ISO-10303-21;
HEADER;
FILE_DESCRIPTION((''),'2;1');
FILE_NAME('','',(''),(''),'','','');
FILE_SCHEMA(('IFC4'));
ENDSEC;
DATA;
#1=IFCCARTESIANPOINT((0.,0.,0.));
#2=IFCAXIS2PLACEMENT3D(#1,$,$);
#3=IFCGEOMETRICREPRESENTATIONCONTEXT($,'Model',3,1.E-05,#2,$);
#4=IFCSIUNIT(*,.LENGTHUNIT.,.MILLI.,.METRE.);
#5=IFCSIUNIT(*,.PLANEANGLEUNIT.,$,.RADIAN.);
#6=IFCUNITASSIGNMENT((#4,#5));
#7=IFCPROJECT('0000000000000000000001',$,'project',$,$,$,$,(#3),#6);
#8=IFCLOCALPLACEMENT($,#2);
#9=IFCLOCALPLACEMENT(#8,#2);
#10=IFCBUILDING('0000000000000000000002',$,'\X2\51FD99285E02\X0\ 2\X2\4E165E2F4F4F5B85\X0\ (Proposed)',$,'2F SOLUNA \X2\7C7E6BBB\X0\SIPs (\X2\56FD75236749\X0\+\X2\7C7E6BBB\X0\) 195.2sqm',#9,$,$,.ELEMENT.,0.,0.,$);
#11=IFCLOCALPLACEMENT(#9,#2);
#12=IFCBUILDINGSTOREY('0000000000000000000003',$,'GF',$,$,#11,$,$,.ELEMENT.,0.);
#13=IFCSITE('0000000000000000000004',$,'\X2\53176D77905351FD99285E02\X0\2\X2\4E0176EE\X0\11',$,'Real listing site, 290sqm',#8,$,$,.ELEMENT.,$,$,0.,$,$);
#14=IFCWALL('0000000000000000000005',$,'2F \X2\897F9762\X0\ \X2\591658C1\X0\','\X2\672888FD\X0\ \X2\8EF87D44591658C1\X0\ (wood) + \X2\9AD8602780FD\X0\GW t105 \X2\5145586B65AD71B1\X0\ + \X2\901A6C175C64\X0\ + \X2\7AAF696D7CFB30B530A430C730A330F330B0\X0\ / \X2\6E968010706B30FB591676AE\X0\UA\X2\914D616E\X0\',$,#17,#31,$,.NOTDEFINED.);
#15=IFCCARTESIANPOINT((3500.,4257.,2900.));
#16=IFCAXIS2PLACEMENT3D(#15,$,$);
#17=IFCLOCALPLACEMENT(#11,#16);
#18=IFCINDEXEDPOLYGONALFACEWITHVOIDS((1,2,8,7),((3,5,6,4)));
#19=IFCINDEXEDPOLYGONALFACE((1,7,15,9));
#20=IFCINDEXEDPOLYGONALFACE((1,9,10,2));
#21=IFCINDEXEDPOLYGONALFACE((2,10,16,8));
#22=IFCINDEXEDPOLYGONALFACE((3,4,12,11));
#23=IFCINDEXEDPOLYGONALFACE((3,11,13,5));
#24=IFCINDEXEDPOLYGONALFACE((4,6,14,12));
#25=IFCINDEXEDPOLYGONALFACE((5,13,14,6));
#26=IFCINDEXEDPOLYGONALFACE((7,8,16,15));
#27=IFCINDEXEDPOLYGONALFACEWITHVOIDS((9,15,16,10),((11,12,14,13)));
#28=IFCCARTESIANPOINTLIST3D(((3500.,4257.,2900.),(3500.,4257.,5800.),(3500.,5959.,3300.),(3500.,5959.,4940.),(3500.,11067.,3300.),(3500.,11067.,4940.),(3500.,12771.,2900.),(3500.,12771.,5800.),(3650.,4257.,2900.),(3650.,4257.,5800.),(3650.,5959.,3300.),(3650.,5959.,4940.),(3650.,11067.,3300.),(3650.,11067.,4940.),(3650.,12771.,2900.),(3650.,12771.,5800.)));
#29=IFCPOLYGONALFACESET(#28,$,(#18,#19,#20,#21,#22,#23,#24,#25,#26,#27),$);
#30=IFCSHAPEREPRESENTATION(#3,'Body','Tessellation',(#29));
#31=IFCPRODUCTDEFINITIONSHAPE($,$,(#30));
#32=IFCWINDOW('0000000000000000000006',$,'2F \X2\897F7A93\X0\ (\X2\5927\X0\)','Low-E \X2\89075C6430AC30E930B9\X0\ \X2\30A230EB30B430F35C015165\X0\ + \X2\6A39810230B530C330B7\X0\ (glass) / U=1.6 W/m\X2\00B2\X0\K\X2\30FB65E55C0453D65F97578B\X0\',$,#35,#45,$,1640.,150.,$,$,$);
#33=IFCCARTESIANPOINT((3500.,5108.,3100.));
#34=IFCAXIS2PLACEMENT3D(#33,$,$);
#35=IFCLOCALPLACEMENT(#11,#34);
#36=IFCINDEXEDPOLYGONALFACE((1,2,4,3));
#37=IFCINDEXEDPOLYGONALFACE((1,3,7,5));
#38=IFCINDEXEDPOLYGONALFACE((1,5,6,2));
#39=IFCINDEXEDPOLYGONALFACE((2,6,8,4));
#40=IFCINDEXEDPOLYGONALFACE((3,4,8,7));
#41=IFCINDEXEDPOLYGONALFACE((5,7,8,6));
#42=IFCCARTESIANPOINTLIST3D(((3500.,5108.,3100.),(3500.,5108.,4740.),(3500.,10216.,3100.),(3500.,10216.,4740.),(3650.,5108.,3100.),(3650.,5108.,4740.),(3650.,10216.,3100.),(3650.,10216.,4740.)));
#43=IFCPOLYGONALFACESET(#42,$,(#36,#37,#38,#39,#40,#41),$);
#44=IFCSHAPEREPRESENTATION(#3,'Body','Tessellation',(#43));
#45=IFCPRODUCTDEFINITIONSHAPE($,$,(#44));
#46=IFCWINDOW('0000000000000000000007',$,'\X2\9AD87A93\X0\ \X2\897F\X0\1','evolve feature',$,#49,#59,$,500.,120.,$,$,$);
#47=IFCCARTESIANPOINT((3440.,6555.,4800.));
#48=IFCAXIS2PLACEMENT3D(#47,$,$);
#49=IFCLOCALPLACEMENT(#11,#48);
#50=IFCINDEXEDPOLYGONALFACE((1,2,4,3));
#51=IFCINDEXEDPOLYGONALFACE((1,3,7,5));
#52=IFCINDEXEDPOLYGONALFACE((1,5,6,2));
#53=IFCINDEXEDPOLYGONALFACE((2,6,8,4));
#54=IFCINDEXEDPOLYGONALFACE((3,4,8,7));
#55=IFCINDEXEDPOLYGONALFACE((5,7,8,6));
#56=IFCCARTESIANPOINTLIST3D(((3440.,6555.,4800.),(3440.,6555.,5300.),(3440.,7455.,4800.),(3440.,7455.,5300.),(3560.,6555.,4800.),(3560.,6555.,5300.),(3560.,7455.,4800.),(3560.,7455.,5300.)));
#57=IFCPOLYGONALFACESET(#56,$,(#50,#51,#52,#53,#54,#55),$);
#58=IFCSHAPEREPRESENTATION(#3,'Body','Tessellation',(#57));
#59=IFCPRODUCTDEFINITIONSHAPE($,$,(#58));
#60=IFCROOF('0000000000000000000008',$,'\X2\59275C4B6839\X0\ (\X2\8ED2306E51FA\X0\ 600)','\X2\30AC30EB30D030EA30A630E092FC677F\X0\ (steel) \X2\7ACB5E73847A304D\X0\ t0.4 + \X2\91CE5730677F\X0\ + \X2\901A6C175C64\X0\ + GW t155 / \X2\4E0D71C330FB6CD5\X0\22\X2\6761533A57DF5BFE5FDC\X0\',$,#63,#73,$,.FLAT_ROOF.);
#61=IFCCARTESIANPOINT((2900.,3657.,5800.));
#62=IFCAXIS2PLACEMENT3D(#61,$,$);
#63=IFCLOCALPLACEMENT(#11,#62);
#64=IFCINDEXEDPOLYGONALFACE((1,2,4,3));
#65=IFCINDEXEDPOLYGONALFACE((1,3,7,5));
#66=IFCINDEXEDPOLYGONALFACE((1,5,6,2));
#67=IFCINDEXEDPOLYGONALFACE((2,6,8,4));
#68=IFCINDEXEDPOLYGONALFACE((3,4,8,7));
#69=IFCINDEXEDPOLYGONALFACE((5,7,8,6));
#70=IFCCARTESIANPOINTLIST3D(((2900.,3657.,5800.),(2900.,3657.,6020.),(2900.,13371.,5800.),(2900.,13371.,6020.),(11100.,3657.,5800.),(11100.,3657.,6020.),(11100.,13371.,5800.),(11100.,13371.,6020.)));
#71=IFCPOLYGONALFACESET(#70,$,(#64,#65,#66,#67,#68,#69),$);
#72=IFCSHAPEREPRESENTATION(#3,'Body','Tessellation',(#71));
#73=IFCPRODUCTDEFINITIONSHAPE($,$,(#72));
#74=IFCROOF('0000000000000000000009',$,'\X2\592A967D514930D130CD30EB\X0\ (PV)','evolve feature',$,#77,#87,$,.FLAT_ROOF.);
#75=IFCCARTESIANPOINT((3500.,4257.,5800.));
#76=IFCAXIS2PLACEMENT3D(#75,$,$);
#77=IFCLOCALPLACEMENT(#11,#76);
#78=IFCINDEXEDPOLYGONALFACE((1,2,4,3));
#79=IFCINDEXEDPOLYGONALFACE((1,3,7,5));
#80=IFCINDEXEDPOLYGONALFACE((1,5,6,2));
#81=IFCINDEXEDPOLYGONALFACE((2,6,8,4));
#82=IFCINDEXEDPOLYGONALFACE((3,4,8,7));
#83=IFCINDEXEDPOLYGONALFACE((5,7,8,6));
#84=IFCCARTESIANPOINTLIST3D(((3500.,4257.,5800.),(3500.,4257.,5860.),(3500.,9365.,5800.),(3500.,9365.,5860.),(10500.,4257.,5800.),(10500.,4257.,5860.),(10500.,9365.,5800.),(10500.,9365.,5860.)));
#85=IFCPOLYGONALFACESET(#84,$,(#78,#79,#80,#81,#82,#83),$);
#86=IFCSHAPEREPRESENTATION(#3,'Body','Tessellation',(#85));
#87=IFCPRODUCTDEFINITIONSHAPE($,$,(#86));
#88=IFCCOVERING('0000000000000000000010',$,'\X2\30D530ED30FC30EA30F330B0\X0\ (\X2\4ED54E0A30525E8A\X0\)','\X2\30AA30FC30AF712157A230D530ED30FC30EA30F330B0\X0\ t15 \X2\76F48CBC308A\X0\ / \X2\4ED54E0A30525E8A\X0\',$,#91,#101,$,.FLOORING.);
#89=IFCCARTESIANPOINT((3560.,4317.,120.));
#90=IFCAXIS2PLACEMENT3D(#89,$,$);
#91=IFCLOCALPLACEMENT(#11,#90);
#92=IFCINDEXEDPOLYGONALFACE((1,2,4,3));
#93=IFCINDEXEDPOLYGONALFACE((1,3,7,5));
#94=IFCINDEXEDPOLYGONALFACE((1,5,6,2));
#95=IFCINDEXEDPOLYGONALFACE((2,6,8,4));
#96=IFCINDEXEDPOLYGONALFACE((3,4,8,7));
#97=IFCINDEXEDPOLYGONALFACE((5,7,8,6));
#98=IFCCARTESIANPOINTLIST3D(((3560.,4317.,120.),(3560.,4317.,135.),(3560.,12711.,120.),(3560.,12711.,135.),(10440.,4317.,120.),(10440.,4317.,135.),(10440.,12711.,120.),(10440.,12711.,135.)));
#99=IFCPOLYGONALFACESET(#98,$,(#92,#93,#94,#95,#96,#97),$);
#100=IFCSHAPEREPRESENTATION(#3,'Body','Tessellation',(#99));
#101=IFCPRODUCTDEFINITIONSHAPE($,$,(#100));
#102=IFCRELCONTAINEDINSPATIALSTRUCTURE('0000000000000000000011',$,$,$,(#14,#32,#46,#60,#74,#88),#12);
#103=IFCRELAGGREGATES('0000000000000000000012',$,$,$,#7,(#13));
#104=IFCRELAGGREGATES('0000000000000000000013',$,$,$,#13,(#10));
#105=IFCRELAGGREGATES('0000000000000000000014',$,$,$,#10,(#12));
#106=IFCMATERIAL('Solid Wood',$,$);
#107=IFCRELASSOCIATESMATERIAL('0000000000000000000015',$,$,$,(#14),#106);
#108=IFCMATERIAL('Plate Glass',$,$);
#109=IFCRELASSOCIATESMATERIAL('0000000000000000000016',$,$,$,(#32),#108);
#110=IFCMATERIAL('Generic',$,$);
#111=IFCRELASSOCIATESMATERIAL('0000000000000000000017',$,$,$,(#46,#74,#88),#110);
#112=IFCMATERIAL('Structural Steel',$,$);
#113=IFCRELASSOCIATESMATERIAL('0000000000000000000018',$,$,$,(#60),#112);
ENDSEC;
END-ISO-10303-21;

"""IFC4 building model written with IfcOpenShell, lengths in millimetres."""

from ifc_helpers import new_model, si_unit, frame, frame_2d, origin, place, context, project, spatial, rectangle, extrude, material, element, fill, save


model = new_model("IFC4")

# Units and contexts
model_context = context("Model", 3, precision=1e-05, world=origin())
ifc_project = project(units=[si_unit("LENGTHUNIT", "METRE", prefix="MILLI"), si_unit("PLANEANGLEUNIT", "RADIAN")], contexts=[model_context])

# Site, building, storey
site_placement = place(None, origin())
site = spatial("IfcSite", under=ifc_project, at=site_placement, Name="北海道函館市2丁目11", ObjectType="Real listing site, 290sqm", CompositionType="ELEMENT", RefElevation=0.0)
building_placement = place(site_placement, origin())
building = spatial("IfcBuilding", under=site, at=building_placement, Name="函館市 2世帯住宅 (Proposed)", ObjectType="2F SOLUNA 籾殻SIPs (国産杉+籾殻) 195.2sqm", CompositionType="ELEMENT", ElevationOfRefHeight=0.0, ElevationOfTerrain=0.0)
storey_placement = place(building_placement, origin())
storey = spatial("IfcBuildingStorey", under=building, at=storey_placement, Name="GF", CompositionType="ELEMENT", Elevation=0.0)

# Shared definitions
ifc_material_1 = material(Name="Solid Wood")

# Shared definitions
ifc_material_2 = material(Name="Plate Glass")
ifc_material_3 = material(Name="Generic")

# Wall, openings, windows
wall_1_placement = place(storey_placement, frame((3500.0, 4257.0, 2900.0)))
wall_1 = element("IfcWall", 1, at=wall_1_placement, inside=storey, material=ifc_material_1, Name="2F 西面 外壁", Description="木製 軸組外壁 (wood) + 高性能GW t105 充填断熱 + 通気層 + 窯業系サイディング / 準耐火・外皮UA配慮", PredefinedType="NOTDEFINED", context=model_context, shape_type="SweptSolid", body=[
    extrude(rectangle(XDim=150.0, YDim=8514.0, at=frame_2d((75.0, 4257.0))), frame((3500.0, 4257.0, 2900.0)), (0.0, 0.0, 1.0), 2900.0),
])
opening_1_placement = place(storey_placement, frame((3500.0, 5108.0, 3100.0)))
opening_1 = element("IfcOpeningElement", 2, at=opening_1_placement, cuts=wall_1, PredefinedType="NOTDEFINED", context=model_context, shape_type="SweptSolid", body=[
    extrude(rectangle(XDim=150.0, YDim=5108.0, at=frame_2d((75.0, 2554.0))), frame((3500.0, 5108.0, 3100.0)), (0.0, 0.0, 1.0), 1640.0),
])
opening_2_placement = place(storey_placement, frame((3440.0, 6555.0, 4800.0)))
opening_2 = element("IfcOpeningElement", 3, at=opening_2_placement, cuts=wall_1, PredefinedType="NOTDEFINED", context=model_context, shape_type="SweptSolid", body=[
    extrude(rectangle(XDim=120.0, YDim=900.0, at=frame_2d((60.0, 450.0))), frame((3440.0, 6555.0, 4800.0)), (0.0, 0.0, 1.0), 500.0),
])
window_1_placement = place(storey_placement, frame((3500.0, 5108.0, 3100.0)))
window_1 = element("IfcWindow", 4, at=window_1_placement, inside=storey, material=ifc_material_2, Name="2F 西窓 (大)", Description="Low-E 複層ガラス アルゴン封入 + 樹脂サッシ (glass) / U=1.6 W/m²K・日射取得型", OverallHeight=1640.0, OverallWidth=150.0, context=model_context, shape_type="SweptSolid", body=[
    extrude(rectangle(XDim=150.0, YDim=5108.0, at=frame_2d((75.0, 2554.0))), frame((3500.0, 5108.0, 3100.0)), (0.0, 0.0, 1.0), 1640.0),
])
fill(opening_1, window_1)
window_2_placement = place(storey_placement, frame((3440.0, 6555.0, 4800.0)))
window_2 = element("IfcWindow", 5, at=window_2_placement, inside=storey, material=ifc_material_3, Name="高窓 西1", Description="evolve feature", OverallHeight=500.0, OverallWidth=120.0, context=model_context, shape_type="SweptSolid", body=[
    extrude(rectangle(XDim=120.0, YDim=900.0, at=frame_2d((60.0, 450.0))), frame((3440.0, 6555.0, 4800.0)), (0.0, 0.0, 1.0), 500.0),
])
fill(opening_2, window_2)

# Roofs
ifc_material_4 = material(Name="Structural Steel")
roof_1_placement = place(storey_placement, frame((2900.0, 3657.0, 5800.0)))
element("IfcRoof", 6, at=roof_1_placement, inside=storey, material=ifc_material_4, Name="大屋根 (軒の出 600)", Description="ガルバリウム鋼板 (steel) 立平葺き t0.4 + 野地板 + 通気層 + GW t155 / 不燃・法22条区域対応", PredefinedType="FLAT_ROOF", context=model_context, shape_type="SweptSolid", body=[
    extrude(rectangle(XDim=8200.0, YDim=9714.0, at=frame_2d((4100.0, 4857.0))), frame((2900.0, 3657.0, 5800.0)), (0.0, 0.0, 1.0), 220.0),
])
roof_2_placement = place(storey_placement, frame((3500.0, 4257.0, 5800.0)))
element("IfcRoof", 7, at=roof_2_placement, inside=storey, material=ifc_material_3, Name="太陽光パネル (PV)", Description="evolve feature", PredefinedType="FLAT_ROOF", context=model_context, shape_type="SweptSolid", body=[
    extrude(rectangle(XDim=7000.0, YDim=5108.0, at=frame_2d((3500.0, 2554.0))), frame((3500.0, 4257.0, 5800.0)), (0.0, 0.0, 1.0), 60.0),
])

# Covering
covering_placement = place(storey_placement, frame((3560.0, 4317.0, 120.0)))
element("IfcCovering", 8, at=covering_placement, inside=storey, material=ifc_material_3, Name="フローリング (仕上げ床)", Description="オーク無垢フローリング t15 直貼り / 仕上げ床", PredefinedType="FLOORING", context=model_context, shape_type="SweptSolid", body=[
    extrude(rectangle(XDim=6880.0, YDim=8394.0, at=frame_2d((3440.0, 4197.0))), frame((3560.0, 4317.0, 120.0)), (0.0, 0.0, 1.0), 15.0),
])

save(model, "model.ifc")
